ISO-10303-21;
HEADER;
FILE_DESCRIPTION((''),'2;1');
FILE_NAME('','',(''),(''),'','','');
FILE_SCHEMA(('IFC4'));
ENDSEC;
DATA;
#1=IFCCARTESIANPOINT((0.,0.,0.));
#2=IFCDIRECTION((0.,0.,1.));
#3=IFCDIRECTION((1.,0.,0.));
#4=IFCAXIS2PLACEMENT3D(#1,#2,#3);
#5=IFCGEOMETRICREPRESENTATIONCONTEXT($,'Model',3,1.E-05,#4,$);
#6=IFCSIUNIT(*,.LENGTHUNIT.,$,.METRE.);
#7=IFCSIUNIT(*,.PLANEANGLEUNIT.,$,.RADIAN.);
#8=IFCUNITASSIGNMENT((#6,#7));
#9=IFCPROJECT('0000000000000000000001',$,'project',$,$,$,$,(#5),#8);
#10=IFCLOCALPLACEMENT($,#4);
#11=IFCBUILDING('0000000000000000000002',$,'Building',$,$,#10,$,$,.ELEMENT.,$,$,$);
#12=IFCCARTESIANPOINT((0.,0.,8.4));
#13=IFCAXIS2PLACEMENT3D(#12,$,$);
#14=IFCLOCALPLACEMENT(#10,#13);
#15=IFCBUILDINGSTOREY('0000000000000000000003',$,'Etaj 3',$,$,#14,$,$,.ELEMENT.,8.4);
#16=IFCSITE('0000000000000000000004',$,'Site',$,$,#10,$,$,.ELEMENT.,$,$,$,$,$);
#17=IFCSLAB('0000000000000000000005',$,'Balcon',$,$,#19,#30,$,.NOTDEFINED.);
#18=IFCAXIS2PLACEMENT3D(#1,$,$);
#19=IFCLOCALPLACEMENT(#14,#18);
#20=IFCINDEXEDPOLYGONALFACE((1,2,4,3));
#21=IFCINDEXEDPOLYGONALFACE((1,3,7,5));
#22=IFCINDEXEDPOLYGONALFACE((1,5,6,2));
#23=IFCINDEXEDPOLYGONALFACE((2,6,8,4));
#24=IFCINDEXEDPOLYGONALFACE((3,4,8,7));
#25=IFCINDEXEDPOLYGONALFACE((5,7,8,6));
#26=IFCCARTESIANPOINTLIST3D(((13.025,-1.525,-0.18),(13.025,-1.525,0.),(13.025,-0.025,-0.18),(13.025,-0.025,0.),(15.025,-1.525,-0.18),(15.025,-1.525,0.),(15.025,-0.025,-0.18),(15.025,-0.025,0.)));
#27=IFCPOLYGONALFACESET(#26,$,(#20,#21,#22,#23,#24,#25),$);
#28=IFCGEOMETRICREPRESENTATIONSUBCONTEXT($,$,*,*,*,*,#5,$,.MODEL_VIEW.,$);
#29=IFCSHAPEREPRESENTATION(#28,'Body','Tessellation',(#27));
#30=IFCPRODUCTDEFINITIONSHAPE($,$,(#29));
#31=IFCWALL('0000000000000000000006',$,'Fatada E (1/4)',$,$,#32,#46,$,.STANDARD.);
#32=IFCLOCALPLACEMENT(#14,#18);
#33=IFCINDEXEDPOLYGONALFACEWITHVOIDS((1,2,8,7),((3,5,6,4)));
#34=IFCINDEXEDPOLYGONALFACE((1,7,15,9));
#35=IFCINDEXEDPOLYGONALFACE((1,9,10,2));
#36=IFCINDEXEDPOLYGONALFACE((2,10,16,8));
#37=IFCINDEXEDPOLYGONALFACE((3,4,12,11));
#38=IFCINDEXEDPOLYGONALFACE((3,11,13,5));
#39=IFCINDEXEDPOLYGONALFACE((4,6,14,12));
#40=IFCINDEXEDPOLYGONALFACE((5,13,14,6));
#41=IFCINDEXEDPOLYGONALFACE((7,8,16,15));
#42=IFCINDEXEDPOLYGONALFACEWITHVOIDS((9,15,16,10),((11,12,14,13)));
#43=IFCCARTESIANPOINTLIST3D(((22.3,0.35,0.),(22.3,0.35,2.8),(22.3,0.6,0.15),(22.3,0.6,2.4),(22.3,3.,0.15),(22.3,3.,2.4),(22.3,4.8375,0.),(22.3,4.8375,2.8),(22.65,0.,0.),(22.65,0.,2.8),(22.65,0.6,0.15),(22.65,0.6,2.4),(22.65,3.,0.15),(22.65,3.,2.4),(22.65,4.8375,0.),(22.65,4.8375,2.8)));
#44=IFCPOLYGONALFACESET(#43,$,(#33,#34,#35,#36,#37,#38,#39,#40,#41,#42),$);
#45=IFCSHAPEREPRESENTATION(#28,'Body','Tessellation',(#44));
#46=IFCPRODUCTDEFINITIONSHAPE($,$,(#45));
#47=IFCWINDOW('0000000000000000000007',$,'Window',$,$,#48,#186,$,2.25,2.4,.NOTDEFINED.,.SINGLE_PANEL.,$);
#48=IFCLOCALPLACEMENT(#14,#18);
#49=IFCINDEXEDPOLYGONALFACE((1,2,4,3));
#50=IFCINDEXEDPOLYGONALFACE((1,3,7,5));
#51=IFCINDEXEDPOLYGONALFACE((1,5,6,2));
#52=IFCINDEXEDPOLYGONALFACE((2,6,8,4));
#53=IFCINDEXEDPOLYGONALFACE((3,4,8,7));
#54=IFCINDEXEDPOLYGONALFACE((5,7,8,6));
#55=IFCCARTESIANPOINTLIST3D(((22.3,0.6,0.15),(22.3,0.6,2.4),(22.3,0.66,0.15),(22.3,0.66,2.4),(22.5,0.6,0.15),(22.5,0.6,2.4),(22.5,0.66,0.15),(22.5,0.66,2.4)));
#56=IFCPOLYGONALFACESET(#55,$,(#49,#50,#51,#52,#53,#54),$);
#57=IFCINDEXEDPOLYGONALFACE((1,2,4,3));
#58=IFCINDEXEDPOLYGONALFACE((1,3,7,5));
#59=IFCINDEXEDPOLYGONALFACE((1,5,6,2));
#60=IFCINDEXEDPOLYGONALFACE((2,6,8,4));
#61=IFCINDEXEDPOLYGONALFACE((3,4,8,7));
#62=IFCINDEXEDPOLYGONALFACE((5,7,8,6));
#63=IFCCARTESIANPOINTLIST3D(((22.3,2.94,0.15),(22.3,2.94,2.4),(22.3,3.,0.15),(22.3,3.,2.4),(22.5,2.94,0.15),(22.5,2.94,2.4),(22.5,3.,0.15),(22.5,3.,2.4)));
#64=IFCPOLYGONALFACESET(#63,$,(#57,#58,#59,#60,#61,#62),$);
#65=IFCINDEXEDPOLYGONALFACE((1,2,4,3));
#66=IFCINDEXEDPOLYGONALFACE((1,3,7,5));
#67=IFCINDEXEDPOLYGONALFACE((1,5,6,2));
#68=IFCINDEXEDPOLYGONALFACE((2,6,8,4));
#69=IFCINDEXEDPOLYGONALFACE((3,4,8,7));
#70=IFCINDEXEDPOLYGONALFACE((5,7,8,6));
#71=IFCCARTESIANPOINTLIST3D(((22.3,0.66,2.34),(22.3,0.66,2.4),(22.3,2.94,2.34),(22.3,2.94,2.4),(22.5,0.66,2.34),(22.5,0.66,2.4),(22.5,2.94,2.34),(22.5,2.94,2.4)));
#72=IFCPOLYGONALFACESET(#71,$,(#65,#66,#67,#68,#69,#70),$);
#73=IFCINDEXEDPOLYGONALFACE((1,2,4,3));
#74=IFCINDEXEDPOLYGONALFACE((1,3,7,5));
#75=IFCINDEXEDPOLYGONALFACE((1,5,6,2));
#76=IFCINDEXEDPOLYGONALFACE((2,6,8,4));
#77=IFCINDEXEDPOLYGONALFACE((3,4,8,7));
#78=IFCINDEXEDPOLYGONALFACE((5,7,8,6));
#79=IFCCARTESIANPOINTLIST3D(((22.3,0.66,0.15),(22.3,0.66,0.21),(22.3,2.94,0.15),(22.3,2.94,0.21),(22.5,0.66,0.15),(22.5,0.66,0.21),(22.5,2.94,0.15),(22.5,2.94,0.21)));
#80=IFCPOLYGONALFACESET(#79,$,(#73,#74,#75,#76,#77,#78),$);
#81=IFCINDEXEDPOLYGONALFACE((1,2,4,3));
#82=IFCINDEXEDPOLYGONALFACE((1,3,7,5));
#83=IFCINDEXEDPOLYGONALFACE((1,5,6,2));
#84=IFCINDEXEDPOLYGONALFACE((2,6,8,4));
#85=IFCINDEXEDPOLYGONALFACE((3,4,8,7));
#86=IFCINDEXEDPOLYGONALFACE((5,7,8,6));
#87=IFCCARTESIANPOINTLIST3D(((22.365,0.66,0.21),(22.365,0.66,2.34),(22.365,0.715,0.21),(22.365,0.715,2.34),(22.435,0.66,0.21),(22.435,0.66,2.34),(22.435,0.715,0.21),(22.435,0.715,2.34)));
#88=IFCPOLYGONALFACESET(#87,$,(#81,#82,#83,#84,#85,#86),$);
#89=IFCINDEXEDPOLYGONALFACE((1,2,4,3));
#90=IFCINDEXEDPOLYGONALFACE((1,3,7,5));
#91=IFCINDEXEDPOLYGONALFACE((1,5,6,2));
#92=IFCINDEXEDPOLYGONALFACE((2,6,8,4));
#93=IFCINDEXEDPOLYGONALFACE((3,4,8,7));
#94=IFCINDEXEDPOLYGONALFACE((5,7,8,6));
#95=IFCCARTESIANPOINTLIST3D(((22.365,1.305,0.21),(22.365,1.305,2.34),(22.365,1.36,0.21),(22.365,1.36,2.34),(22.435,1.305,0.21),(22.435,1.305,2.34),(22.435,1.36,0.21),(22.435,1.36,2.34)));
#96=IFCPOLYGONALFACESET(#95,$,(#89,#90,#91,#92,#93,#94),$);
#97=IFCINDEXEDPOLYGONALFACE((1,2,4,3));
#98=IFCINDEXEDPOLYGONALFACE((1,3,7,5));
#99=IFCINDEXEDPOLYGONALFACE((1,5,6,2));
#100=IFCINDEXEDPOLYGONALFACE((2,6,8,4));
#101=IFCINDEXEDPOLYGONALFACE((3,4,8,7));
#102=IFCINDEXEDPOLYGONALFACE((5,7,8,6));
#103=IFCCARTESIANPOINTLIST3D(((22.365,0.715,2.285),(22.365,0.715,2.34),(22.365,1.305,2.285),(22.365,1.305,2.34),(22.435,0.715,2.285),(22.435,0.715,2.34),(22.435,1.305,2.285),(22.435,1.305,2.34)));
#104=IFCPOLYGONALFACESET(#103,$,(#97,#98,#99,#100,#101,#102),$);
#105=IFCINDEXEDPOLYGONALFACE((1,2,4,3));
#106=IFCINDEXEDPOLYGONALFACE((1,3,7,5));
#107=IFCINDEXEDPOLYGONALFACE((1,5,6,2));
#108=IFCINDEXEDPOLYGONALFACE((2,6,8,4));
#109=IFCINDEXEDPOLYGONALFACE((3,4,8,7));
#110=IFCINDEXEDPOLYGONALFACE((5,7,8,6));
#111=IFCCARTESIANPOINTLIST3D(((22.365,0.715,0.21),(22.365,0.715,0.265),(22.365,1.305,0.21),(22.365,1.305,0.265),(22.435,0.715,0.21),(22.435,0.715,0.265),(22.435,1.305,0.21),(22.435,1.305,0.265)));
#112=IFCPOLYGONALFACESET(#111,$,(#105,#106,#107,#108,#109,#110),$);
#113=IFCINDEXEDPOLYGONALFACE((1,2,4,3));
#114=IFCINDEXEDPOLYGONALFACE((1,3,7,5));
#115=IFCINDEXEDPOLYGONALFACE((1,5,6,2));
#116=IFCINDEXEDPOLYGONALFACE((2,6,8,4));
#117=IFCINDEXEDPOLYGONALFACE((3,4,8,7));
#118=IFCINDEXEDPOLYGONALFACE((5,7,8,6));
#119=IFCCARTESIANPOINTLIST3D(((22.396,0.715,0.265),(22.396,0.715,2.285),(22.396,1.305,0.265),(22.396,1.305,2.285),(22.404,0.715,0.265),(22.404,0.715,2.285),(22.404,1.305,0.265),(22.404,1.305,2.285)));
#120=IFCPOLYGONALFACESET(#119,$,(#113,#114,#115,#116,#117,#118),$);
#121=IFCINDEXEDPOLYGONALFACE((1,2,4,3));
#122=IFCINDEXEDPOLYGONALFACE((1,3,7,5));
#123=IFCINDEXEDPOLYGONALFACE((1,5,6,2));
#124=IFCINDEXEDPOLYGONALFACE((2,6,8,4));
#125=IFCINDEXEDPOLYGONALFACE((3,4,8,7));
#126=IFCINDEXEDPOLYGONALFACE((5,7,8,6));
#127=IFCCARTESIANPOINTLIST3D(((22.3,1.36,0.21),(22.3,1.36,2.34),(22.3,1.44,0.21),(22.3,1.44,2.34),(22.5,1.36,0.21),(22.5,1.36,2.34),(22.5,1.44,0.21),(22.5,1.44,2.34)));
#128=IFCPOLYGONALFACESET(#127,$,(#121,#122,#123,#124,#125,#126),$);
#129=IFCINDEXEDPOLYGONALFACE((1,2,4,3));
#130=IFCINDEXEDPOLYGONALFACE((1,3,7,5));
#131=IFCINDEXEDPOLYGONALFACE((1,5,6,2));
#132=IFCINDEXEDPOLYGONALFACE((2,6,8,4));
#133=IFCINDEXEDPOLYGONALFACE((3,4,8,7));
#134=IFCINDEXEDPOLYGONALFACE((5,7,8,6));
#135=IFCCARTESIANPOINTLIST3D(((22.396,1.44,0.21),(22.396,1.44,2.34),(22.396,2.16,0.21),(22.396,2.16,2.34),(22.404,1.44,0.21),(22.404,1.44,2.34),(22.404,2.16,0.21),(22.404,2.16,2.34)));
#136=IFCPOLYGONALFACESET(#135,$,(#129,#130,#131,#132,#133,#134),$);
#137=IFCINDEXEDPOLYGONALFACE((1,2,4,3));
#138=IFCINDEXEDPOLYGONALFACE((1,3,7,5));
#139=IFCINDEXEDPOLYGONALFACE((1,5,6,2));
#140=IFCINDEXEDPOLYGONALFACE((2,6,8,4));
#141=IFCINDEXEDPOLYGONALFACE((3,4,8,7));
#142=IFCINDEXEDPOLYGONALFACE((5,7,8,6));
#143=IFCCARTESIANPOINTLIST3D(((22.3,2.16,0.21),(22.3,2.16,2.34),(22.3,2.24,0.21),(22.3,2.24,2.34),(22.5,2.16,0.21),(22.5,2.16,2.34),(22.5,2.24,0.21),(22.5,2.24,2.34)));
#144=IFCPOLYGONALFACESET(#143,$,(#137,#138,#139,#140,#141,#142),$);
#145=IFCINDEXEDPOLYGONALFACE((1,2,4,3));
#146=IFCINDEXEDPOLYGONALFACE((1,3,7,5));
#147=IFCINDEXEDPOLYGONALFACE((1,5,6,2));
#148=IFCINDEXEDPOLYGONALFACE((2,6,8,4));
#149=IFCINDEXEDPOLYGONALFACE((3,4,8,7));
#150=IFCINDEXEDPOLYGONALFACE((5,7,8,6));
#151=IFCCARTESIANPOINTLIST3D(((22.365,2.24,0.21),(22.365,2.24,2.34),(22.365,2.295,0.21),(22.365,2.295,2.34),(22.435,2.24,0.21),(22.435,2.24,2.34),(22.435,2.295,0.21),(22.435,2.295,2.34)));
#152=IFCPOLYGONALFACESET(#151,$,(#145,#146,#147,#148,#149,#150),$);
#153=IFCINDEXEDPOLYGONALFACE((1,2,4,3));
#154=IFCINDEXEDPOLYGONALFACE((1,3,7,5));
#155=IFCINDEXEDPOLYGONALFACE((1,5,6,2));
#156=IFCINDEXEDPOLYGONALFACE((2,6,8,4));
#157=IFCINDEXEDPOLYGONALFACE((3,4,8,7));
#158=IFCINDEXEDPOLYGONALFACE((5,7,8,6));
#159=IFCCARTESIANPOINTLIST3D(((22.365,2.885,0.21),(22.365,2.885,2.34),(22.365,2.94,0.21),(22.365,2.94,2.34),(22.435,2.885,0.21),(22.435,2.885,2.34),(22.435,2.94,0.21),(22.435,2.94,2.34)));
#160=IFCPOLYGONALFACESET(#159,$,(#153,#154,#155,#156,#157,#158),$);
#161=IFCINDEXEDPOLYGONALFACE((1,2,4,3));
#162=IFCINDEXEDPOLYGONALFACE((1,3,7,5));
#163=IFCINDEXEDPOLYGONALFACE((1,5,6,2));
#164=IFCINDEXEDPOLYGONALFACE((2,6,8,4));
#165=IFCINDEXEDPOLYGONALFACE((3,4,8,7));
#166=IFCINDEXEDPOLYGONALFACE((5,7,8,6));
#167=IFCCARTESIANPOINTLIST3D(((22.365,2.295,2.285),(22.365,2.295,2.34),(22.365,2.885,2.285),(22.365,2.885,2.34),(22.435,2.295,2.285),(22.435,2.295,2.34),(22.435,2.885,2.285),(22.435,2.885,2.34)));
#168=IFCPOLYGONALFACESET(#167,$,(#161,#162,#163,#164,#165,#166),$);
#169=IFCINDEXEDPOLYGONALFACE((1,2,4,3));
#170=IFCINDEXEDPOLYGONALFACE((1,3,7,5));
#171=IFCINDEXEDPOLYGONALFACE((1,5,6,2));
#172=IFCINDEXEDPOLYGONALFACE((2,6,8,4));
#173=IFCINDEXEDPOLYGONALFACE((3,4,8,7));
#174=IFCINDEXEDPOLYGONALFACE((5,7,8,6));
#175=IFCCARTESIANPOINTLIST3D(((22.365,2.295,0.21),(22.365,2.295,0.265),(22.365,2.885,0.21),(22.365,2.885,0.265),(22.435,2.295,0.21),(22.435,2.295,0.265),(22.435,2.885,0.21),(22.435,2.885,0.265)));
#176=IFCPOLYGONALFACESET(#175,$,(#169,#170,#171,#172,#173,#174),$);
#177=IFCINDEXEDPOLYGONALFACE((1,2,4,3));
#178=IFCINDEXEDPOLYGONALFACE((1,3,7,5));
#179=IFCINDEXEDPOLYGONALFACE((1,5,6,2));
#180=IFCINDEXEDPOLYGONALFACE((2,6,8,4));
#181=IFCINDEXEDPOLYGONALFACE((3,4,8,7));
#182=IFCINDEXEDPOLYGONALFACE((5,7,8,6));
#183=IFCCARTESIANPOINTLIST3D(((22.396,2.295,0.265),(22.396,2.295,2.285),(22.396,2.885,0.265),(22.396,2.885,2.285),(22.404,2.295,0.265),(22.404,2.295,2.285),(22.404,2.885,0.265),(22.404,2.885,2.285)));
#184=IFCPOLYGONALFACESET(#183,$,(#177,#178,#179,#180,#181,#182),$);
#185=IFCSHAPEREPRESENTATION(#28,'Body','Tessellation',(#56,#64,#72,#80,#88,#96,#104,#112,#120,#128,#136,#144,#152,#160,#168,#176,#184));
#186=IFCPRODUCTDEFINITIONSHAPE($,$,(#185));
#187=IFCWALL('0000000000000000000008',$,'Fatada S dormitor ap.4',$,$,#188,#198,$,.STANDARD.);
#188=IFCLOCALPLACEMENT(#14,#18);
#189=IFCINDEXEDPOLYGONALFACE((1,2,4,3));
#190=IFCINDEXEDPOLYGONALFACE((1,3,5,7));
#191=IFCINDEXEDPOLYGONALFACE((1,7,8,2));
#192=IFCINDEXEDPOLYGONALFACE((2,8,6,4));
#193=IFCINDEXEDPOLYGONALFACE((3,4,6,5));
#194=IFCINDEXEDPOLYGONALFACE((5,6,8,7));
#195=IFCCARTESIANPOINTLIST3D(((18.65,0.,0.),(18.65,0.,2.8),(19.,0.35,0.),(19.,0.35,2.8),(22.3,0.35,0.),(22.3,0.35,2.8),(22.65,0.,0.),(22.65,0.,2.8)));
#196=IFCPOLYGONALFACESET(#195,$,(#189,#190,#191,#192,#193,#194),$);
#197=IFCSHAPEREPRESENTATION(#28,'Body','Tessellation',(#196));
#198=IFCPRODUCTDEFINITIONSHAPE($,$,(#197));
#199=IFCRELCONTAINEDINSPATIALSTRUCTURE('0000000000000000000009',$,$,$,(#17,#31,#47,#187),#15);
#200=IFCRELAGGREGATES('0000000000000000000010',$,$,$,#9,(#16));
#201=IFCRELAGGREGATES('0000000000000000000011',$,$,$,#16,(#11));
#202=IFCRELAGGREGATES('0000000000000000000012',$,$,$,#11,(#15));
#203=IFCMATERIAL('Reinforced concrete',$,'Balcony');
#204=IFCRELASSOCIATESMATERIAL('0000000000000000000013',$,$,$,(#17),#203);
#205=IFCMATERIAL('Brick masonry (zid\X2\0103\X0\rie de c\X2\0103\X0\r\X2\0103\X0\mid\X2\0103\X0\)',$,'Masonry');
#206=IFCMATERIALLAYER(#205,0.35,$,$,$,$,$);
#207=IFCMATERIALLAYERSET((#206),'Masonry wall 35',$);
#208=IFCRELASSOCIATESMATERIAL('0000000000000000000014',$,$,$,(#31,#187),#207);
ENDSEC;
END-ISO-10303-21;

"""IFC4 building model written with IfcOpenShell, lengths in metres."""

from ifc_helpers import new_model, si_unit, frame, frame_2d, origin, origin_with_axes, origin_2d, place, context, subcontext, project, spatial, polyline, rectangle, outline, extrude, clip, halfspace, material, layer, layer_set, layer_usage, element, fill, save


model = new_model("IFC4")

# Units and contexts
model_context = context("Model", 3, precision=1e-05, world=origin_with_axes())
sub_context = subcontext(model_context, None, None, "MODEL_VIEW")
ifc_project = project(units=[si_unit("LENGTHUNIT", "METRE"), si_unit("PLANEANGLEUNIT", "RADIAN")], contexts=[model_context])

# Site, building, storey
placement = place(None, origin_with_axes())
site = spatial("IfcSite", under=ifc_project, at=placement, Name="Site", CompositionType="ELEMENT")
building = spatial("IfcBuilding", under=site, at=placement, Name="Building", CompositionType="ELEMENT")
storey_placement = place(placement, frame((0.0, 0.0, 8.4)))
storey = spatial("IfcBuildingStorey", under=building, at=storey_placement, Name="Etaj 3", CompositionType="ELEMENT", Elevation=8.4)

# Slab
ifc_material_1 = material(Name="Reinforced concrete", Category="Balcony")
slab_placement = place(storey_placement, frame((13.025, -1.525, -0.18), z_axis=(0.0, 0.0, 1.0), x_axis=(1.0, 0.0, 0.0)))
element("IfcSlab", 1, at=slab_placement, inside=storey, material=ifc_material_1, Name="Balcon", PredefinedType="NOTDEFINED", context=sub_context, shape_type="SweptSolid", body=[
    extrude(outline(polyline([(0.0, 0.0), (2.0, 0.0), (2.0, 1.5), (0.0, 1.5), (0.0, 0.0)])), origin(), (0.0, 0.0, 1.0), 0.18),
])

# Wall, opening, window
ifc_material_2 = material(Name="Brick masonry (zidărie de cărămidă)", Category="Masonry")
ifc_layer_1 = layer(ifc_material_2, 0.35)
ifc_layer_set_1 = layer_set([ifc_layer_1], Name="Masonry wall 35")
ifc_layer_usage_1 = layer_usage(ifc_layer_set_1, "AXIS2", "POSITIVE", -0.175)
wall_1_placement = place(storey_placement, frame((22.475, 0.0, 0.0), x_axis=(0.0, 1.0, 0.0)))
wall_1 = element("IfcWall", 2, at=wall_1_placement, inside=storey, material=ifc_layer_usage_1, Name="Fatada E (1/4)", PredefinedType="STANDARD", context=sub_context, shape_type="CSG", body=[
    clip(extrude(rectangle(XDim=4.8375, YDim=0.35, at=frame_2d((2.4188, 0.0))), origin(), (0.0, 0.0, 1.0), 2.8), halfspace(frame((0.175, 0.0, 0.0), z_axis=(-0.707107, 0.707107, 0.0)), False)),
])
opening_1_placement = place(wall_1_placement, frame((1.8, 0.225, 0.15), z_axis=(0.0, -1.0, 0.0), x_axis=(1.0, 0.0, 0.0)))
opening_1 = element("IfcOpeningElement", 3, at=opening_1_placement, cuts=wall_1, PredefinedType="OPENING", context=sub_context, shape_type="SweptSolid", body=[
    extrude(rectangle(XDim=2.4, YDim=2.25, at=frame_2d((0.0, 1.125))), origin(), (0.0, 0.0, 1.0), 0.45),
])
window_1_placement = place(wall_1_placement, frame((1.8, 0.175, 0.15), z_axis=(0.0, -1.0, 0.0), x_axis=(1.0, 0.0, 0.0)))
window_1 = element("IfcWindow", 4, at=window_1_placement, inside=storey, Name="Window", OverallHeight=2.25, OverallWidth=2.4, PartitioningType="SINGLE_PANEL", PredefinedType="NOTDEFINED", context=sub_context, shape_type="SweptSolid", body=[
    extrude(rectangle(XDim=0.06, YDim=2.25, at=origin_2d()), frame((-1.17, 1.125, 0.0)), (0.0, 0.0, 1.0), 0.2),
    extrude(rectangle(XDim=0.06, YDim=2.25, at=origin_2d()), frame((1.17, 1.125, 0.0)), (0.0, 0.0, 1.0), 0.2),
    extrude(rectangle(XDim=2.28, YDim=0.06, at=origin_2d()), frame((0.0, 2.22, 0.0)), (0.0, 0.0, 1.0), 0.2),
    extrude(rectangle(XDim=2.28, YDim=0.06, at=origin_2d()), frame((0.0, 0.03, 0.0)), (0.0, 0.0, 1.0), 0.2),
    extrude(rectangle(XDim=0.055, YDim=2.13, at=origin_2d()), frame((-1.1125, 1.125, 0.065)), (0.0, 0.0, 1.0), 0.07),
    extrude(rectangle(XDim=0.055, YDim=2.13, at=origin_2d()), frame((-0.4675, 1.125, 0.065)), (0.0, 0.0, 1.0), 0.07),
    extrude(rectangle(XDim=0.59, YDim=0.055, at=origin_2d()), frame((-0.79, 2.1625, 0.065)), (0.0, 0.0, 1.0), 0.07),
    extrude(rectangle(XDim=0.59, YDim=0.055, at=origin_2d()), frame((-0.79, 0.0875, 0.065)), (0.0, 0.0, 1.0), 0.07),
    extrude(rectangle(XDim=0.59, YDim=2.02, at=origin_2d()), frame((-0.79, 1.125, 0.096)), (0.0, 0.0, 1.0), 0.008),
    extrude(rectangle(XDim=0.08, YDim=2.13, at=origin_2d()), frame((-0.4, 1.125, 0.0)), (0.0, 0.0, 1.0), 0.2),
    extrude(rectangle(XDim=0.72, YDim=2.13, at=origin_2d()), frame((0.0, 1.125, 0.096)), (0.0, 0.0, 1.0), 0.008),
    extrude(rectangle(XDim=0.08, YDim=2.13, at=origin_2d()), frame((0.4, 1.125, 0.0)), (0.0, 0.0, 1.0), 0.2),
    extrude(rectangle(XDim=0.055, YDim=2.13, at=origin_2d()), frame((0.4675, 1.125, 0.065)), (0.0, 0.0, 1.0), 0.07),
    extrude(rectangle(XDim=0.055, YDim=2.13, at=origin_2d()), frame((1.1125, 1.125, 0.065)), (0.0, 0.0, 1.0), 0.07),
    extrude(rectangle(XDim=0.59, YDim=0.055, at=origin_2d()), frame((0.79, 2.1625, 0.065)), (0.0, 0.0, 1.0), 0.07),
    extrude(rectangle(XDim=0.59, YDim=0.055, at=origin_2d()), frame((0.79, 0.0875, 0.065)), (0.0, 0.0, 1.0), 0.07),
    extrude(rectangle(XDim=0.59, YDim=2.02, at=origin_2d()), frame((0.79, 1.125, 0.096)), (0.0, 0.0, 1.0), 0.008),
])
fill(opening_1, window_1)

# Wall
wall_2_placement = place(storey_placement, frame((18.65, 0.175, 0.0), x_axis=(1.0, 0.0, 0.0)))
element("IfcWall", 5, at=wall_2_placement, inside=storey, material=ifc_layer_usage_1, Name="Fatada S dormitor ap.4", PredefinedType="STANDARD", context=sub_context, shape_type="CSG", body=[
    clip(clip(extrude(rectangle(XDim=4.0, YDim=0.35, at=frame_2d((2.0, 0.0))), origin(), (0.0, 0.0, 1.0), 2.8), halfspace(frame((0.175, 0.0, 0.0), z_axis=(-0.707107, 0.707107, 0.0)), False)), halfspace(frame((3.825, 0.0, 0.0), z_axis=(0.707107, 0.707107, 0.0)), False)),
])

save(model, "model.ifc")
